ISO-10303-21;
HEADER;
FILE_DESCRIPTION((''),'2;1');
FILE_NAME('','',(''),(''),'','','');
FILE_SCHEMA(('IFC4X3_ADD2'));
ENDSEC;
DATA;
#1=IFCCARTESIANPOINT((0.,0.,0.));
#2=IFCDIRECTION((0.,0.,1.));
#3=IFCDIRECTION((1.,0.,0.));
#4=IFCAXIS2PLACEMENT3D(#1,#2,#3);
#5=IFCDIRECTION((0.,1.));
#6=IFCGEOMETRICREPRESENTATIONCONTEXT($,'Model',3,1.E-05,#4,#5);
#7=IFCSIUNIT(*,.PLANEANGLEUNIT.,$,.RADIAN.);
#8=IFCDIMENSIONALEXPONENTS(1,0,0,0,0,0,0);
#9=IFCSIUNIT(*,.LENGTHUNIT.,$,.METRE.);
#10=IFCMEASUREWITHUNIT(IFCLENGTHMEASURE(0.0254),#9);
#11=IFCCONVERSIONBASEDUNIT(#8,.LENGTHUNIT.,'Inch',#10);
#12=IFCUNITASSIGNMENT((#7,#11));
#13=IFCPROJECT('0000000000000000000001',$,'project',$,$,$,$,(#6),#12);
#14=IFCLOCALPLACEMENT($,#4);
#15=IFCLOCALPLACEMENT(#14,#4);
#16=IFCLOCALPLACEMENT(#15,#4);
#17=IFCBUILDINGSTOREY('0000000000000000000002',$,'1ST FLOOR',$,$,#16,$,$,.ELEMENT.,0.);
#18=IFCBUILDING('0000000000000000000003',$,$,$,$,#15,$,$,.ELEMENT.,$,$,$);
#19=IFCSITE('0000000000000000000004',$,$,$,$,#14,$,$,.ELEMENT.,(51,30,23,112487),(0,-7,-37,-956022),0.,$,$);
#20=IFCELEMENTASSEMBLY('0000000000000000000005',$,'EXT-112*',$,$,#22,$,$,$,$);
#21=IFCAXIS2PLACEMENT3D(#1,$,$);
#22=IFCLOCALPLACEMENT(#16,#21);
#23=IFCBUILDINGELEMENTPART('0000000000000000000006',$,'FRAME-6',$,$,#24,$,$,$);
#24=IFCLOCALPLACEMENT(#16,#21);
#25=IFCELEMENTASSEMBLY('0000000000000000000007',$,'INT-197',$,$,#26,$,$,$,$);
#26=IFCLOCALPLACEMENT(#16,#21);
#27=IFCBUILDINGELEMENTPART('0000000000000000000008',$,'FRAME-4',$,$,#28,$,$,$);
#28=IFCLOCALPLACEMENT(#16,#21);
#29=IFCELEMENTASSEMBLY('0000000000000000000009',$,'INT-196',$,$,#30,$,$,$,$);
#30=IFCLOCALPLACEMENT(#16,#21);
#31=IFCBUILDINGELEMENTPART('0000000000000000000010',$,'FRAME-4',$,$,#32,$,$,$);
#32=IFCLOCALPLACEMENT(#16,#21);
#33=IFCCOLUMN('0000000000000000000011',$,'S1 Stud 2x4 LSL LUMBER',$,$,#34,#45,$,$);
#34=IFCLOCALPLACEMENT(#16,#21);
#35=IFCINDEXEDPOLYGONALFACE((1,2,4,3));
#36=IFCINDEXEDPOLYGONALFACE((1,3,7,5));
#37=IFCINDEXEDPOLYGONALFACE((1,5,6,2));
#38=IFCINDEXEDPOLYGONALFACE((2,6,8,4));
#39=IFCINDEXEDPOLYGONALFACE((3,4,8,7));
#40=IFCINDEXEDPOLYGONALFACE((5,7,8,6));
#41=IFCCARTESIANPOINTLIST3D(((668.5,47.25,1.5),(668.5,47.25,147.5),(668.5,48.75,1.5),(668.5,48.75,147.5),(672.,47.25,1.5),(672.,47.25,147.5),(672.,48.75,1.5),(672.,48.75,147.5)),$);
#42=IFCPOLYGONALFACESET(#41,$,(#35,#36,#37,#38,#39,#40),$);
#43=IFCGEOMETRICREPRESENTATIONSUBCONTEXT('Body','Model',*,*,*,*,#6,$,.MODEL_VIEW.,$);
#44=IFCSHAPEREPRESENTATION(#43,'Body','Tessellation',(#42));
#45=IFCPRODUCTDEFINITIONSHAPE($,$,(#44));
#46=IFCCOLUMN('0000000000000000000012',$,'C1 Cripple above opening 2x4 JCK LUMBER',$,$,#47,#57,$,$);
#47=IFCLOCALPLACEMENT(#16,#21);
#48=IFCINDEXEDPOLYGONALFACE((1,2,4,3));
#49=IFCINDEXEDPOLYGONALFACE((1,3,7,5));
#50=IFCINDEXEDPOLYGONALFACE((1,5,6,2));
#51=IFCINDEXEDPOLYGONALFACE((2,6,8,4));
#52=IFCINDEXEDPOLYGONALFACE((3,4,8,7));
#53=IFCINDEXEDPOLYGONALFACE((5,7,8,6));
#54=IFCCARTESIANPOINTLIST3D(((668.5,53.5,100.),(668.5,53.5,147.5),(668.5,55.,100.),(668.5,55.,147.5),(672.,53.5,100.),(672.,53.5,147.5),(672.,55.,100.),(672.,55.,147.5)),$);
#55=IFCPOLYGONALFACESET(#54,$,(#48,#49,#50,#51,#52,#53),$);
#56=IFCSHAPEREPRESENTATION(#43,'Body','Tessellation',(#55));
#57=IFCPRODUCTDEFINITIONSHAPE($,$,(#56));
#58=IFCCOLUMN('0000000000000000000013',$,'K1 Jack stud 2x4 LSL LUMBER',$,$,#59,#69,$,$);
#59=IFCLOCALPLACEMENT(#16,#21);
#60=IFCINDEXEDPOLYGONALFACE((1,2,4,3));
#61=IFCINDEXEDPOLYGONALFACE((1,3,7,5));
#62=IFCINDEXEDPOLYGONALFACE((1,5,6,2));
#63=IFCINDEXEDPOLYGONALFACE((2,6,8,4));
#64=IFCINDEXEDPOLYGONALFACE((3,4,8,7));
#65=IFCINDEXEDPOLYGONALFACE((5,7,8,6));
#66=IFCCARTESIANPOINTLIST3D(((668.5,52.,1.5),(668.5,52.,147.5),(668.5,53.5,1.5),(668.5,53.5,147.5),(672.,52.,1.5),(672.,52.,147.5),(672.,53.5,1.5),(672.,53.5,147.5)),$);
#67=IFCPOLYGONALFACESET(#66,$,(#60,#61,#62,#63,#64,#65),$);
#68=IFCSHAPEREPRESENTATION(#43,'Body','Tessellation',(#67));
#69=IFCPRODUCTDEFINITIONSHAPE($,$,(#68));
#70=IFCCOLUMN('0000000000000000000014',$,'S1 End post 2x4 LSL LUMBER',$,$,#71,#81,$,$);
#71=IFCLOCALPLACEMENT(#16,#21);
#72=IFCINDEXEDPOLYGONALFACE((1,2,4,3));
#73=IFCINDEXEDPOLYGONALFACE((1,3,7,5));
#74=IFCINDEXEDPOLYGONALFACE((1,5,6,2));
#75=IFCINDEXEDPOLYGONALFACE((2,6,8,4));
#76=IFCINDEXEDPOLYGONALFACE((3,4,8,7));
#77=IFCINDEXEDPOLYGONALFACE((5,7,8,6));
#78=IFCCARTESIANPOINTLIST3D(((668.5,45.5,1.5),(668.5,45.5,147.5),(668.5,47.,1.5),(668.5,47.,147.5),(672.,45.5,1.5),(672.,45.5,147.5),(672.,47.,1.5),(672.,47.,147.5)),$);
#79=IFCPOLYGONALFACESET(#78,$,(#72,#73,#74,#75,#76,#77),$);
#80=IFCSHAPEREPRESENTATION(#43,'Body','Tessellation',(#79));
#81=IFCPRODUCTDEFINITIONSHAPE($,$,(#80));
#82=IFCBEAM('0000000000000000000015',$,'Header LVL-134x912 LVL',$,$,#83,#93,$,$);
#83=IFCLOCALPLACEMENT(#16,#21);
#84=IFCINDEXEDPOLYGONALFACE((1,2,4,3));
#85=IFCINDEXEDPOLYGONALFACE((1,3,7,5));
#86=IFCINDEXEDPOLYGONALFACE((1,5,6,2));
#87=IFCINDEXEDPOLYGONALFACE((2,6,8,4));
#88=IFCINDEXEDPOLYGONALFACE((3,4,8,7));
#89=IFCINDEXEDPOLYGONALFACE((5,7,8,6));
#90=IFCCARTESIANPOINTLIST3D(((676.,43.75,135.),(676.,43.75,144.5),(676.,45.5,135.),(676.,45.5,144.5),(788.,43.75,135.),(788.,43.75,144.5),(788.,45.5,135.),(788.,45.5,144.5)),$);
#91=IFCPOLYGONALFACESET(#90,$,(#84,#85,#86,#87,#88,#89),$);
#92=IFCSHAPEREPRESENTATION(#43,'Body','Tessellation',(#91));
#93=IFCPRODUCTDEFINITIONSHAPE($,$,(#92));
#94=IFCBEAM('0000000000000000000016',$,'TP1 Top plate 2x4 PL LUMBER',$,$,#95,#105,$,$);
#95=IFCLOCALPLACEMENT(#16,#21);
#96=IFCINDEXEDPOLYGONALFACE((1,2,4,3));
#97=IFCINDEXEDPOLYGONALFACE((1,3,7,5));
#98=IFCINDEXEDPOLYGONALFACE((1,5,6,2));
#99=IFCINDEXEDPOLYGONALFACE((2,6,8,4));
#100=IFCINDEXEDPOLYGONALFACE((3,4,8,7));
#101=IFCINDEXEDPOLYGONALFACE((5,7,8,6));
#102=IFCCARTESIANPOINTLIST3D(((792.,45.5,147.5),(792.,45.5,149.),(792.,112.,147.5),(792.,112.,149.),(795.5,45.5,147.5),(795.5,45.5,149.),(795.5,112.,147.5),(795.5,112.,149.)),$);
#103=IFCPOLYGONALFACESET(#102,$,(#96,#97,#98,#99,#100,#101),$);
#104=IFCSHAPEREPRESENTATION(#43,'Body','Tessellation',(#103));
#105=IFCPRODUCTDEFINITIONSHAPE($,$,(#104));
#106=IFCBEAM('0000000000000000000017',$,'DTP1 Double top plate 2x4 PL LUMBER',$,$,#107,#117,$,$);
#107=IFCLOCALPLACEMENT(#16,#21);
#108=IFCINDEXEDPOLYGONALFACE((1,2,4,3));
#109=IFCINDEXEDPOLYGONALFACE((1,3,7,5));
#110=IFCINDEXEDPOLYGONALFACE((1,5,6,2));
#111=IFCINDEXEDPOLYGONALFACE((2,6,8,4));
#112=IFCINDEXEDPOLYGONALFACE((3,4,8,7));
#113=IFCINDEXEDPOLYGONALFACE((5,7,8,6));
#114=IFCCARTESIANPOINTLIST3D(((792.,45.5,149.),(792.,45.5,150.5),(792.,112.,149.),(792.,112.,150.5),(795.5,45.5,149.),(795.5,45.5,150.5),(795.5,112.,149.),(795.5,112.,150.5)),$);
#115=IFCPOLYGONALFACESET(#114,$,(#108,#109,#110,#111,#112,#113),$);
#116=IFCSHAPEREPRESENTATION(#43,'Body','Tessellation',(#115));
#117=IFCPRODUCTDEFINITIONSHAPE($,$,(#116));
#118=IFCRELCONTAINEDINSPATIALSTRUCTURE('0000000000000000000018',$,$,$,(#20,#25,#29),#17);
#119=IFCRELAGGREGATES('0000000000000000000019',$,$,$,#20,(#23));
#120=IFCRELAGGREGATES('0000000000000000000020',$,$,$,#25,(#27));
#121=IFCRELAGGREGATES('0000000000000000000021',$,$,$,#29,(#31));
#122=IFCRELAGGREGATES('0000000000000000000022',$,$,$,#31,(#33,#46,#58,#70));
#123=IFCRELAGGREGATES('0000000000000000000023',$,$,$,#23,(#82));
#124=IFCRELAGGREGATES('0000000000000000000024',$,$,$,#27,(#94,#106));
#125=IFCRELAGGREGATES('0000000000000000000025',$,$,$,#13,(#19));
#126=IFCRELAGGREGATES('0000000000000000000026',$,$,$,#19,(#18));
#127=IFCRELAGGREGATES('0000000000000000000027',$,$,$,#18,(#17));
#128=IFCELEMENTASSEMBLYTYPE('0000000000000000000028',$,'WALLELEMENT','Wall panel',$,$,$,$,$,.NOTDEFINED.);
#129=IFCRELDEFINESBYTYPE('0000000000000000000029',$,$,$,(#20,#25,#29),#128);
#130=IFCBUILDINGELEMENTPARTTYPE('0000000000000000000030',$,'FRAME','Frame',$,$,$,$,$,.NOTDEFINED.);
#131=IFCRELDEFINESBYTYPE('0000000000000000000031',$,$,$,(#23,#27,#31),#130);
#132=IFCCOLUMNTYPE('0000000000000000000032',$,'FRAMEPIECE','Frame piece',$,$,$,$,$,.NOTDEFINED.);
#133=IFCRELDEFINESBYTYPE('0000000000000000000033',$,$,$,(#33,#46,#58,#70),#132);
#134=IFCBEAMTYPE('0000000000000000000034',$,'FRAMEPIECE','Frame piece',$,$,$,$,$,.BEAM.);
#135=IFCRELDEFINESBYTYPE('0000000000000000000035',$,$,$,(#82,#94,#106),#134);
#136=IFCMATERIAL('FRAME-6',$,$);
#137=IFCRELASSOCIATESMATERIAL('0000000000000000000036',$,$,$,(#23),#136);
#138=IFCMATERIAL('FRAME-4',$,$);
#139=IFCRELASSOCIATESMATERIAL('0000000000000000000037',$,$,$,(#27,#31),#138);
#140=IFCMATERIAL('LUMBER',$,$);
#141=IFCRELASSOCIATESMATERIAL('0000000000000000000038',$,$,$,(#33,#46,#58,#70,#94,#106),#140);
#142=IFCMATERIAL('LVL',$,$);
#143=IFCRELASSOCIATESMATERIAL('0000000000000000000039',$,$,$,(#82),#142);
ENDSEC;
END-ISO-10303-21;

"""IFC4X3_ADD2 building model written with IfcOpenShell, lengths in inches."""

from ifc_helpers import new_model, entity, si_unit, converted_unit, direction, frame, origin_with_axes, origin_2d_with_axis, place, context, subcontext, project, spatial, rectangle, extrude, material, type_object, element, aggregate, save


model = new_model("IFC4X3_ADD2")

# Units and contexts
model_context = context("Model", 3, precision=1e-05, world=origin_with_axes(), true_north=direction((0.0, 1.0)))
body_context = subcontext(model_context, "Body", "Model", "MODEL_VIEW")
ifc_project = project(units=[si_unit("PLANEANGLEUNIT", "RADIAN"), converted_unit("LENGTHUNIT", "Inch", entity("IfcLengthMeasure", 0.0254), si_unit("LENGTHUNIT", "METRE"), dimensions=[1, 0, 0, 0, 0, 0, 0])], contexts=[model_context])

# Site, building, storey
site_placement = place(None, origin_with_axes())
site = spatial("IfcSite", under=ifc_project, at=site_placement, CompositionType="ELEMENT", RefLatitude=(51, 30, 23, 112487), RefLongitude=(0, -7, -37, -956022), RefElevation=0.0)
building_placement = place(site_placement, origin_with_axes())
building = spatial("IfcBuilding", under=site, at=building_placement, CompositionType="ELEMENT")
storey_placement = place(building_placement, origin_with_axes())
storey = spatial("IfcBuildingStorey", under=building, at=storey_placement, Name="1ST FLOOR", CompositionType="ELEMENT", Elevation=0.0)

# Element assemblies, building element parts, columns
element_assembly_type = type_object("IfcElementAssemblyType", Name="WALLELEMENT", Description="Wall panel", PredefinedType="NOTDEFINED")
assembly_1_placement = place(storey_placement, origin_with_axes())
assembly_1 = element("IfcElementAssembly", 1, at=assembly_1_placement, inside=storey, type_object=element_assembly_type, Name="EXT-112*")
ifc_material_1 = material(Name="FRAME-6")
building_element_part_type = type_object("IfcBuildingElementPartType", Name="FRAME", Description="Frame", PredefinedType="NOTDEFINED")
building_element_part_1_placement = place(storey_placement, origin_with_axes())
building_element_part_1 = element("IfcBuildingElementPart", 2, at=building_element_part_1_placement, type_object=building_element_part_type, material=ifc_material_1, Name="FRAME-6")
aggregate(assembly_1, [building_element_part_1])
ifc_material_2 = material(Name="LUMBER")
column_type = type_object("IfcColumnType", Name="FRAMEPIECE", Description="Frame piece", PredefinedType="NOTDEFINED")
assembly_2_placement = place(storey_placement, origin_with_axes())
assembly_2 = element("IfcElementAssembly", 3, at=assembly_2_placement, inside=storey, type_object=element_assembly_type, Name="INT-197")
ifc_material_3 = material(Name="FRAME-4")
building_element_part_2_placement = place(storey_placement, origin_with_axes())
building_element_part_2 = element("IfcBuildingElementPart", 4, at=building_element_part_2_placement, type_object=building_element_part_type, material=ifc_material_3, Name="FRAME-4")
aggregate(assembly_2, [building_element_part_2])
assembly_3_placement = place(storey_placement, origin_with_axes())
assembly_3 = element("IfcElementAssembly", 5, at=assembly_3_placement, inside=storey, type_object=element_assembly_type, Name="INT-196")
building_element_part_3_placement = place(storey_placement, origin_with_axes())
building_element_part_3 = element("IfcBuildingElementPart", 6, at=building_element_part_3_placement, type_object=building_element_part_type, material=ifc_material_3, Name="FRAME-4")
aggregate(assembly_3, [building_element_part_3])
column_1_placement = place(storey_placement, frame((670.25, 48.0, 147.5), z_axis=(0.0, 0.0, -1.0), x_axis=(0.0, 1.0, 0.0)))
column_1 = element("IfcColumn", 7, at=column_1_placement, type_object=column_type, material=ifc_material_2, Name="S1 Stud 2x4 LSL LUMBER", context=body_context, shape_type="SweptSolid", body=[
    extrude(rectangle(XDim=1.5, YDim=3.5, at=origin_2d_with_axis()), origin_with_axes(), (0.0, 0.0, 1.0), 146.0),
])
column_2_placement = place(storey_placement, frame((670.25, 54.25, 147.5), z_axis=(0.0, 0.0, -1.0), x_axis=(0.0, 1.0, 0.0)))
column_2 = element("IfcColumn", 8, at=column_2_placement, type_object=column_type, material=ifc_material_2, Name="C1 Cripple above opening 2x4 JCK LUMBER", context=body_context, shape_type="SweptSolid", body=[
    extrude(rectangle(XDim=1.5, YDim=3.5, at=origin_2d_with_axis()), origin_with_axes(), (0.0, 0.0, 1.0), 47.5),
])
column_3_placement = place(storey_placement, frame((670.25, 52.75, 147.5), z_axis=(0.0, 0.0, -1.0), x_axis=(0.0, 1.0, 0.0)))
column_3 = element("IfcColumn", 9, at=column_3_placement, type_object=column_type, material=ifc_material_2, Name="K1 Jack stud 2x4 LSL LUMBER", context=body_context, shape_type="SweptSolid", body=[
    extrude(rectangle(XDim=1.5, YDim=3.5, at=origin_2d_with_axis()), origin_with_axes(), (0.0, 0.0, 1.0), 146.0),
])
column_4_placement = place(storey_placement, frame((670.25, 46.25, 147.5), z_axis=(0.0, 0.0, -1.0), x_axis=(0.0, 1.0, 0.0)))
column_4 = element("IfcColumn", 10, at=column_4_placement, type_object=column_type, material=ifc_material_2, Name="S1 End post 2x4 LSL LUMBER", context=body_context, shape_type="SweptSolid", body=[
    extrude(rectangle(XDim=1.5, YDim=3.5, at=origin_2d_with_axis()), origin_with_axes(), (0.0, 0.0, 1.0), 146.0),
])
aggregate(building_element_part_3, [column_1, column_2, column_3, column_4])

# Beams
ifc_material_4 = material(Name="LVL")
beam_type = type_object("IfcBeamType", Name="FRAMEPIECE", Description="Frame piece", PredefinedType="BEAM")
beam_1_placement = place(storey_placement, frame((676.0, 44.625, 139.75), z_axis=(1.0, 0.0, 0.0), x_axis=(0.0, 1.0, 0.0)))
beam_1 = element("IfcBeam", 11, at=beam_1_placement, type_object=beam_type, material=ifc_material_4, Name="Header LVL-134x912 LVL", context=body_context, shape_type="SweptSolid", body=[
    extrude(rectangle(XDim=1.75, YDim=9.5, at=origin_2d_with_axis()), origin_with_axes(), (0.0, 0.0, 1.0), 112.0),
])
aggregate(building_element_part_1, [beam_1])
beam_2_placement = place(storey_placement, frame((793.75, 45.5, 148.25), z_axis=(0.0, 1.0, 0.0), x_axis=(0.0, 0.0, -1.0)))
beam_2 = element("IfcBeam", 12, at=beam_2_placement, type_object=beam_type, material=ifc_material_2, Name="TP1 Top plate 2x4 PL LUMBER", context=body_context, shape_type="SweptSolid", body=[
    extrude(rectangle(XDim=1.5, YDim=3.5, at=origin_2d_with_axis()), origin_with_axes(), (0.0, 0.0, 1.0), 66.5),
])
beam_3_placement = place(storey_placement, frame((793.75, 45.5, 149.75), z_axis=(0.0, 1.0, 0.0), x_axis=(0.0, 0.0, -1.0)))
beam_3 = element("IfcBeam", 13, at=beam_3_placement, type_object=beam_type, material=ifc_material_2, Name="DTP1 Double top plate 2x4 PL LUMBER", context=body_context, shape_type="SweptSolid", body=[
    extrude(rectangle(XDim=1.5, YDim=3.5, at=origin_2d_with_axis()), origin_with_axes(), (0.0, 0.0, 1.0), 66.5),
])
aggregate(building_element_part_2, [beam_2, beam_3])

save(model, "model.ifc")
